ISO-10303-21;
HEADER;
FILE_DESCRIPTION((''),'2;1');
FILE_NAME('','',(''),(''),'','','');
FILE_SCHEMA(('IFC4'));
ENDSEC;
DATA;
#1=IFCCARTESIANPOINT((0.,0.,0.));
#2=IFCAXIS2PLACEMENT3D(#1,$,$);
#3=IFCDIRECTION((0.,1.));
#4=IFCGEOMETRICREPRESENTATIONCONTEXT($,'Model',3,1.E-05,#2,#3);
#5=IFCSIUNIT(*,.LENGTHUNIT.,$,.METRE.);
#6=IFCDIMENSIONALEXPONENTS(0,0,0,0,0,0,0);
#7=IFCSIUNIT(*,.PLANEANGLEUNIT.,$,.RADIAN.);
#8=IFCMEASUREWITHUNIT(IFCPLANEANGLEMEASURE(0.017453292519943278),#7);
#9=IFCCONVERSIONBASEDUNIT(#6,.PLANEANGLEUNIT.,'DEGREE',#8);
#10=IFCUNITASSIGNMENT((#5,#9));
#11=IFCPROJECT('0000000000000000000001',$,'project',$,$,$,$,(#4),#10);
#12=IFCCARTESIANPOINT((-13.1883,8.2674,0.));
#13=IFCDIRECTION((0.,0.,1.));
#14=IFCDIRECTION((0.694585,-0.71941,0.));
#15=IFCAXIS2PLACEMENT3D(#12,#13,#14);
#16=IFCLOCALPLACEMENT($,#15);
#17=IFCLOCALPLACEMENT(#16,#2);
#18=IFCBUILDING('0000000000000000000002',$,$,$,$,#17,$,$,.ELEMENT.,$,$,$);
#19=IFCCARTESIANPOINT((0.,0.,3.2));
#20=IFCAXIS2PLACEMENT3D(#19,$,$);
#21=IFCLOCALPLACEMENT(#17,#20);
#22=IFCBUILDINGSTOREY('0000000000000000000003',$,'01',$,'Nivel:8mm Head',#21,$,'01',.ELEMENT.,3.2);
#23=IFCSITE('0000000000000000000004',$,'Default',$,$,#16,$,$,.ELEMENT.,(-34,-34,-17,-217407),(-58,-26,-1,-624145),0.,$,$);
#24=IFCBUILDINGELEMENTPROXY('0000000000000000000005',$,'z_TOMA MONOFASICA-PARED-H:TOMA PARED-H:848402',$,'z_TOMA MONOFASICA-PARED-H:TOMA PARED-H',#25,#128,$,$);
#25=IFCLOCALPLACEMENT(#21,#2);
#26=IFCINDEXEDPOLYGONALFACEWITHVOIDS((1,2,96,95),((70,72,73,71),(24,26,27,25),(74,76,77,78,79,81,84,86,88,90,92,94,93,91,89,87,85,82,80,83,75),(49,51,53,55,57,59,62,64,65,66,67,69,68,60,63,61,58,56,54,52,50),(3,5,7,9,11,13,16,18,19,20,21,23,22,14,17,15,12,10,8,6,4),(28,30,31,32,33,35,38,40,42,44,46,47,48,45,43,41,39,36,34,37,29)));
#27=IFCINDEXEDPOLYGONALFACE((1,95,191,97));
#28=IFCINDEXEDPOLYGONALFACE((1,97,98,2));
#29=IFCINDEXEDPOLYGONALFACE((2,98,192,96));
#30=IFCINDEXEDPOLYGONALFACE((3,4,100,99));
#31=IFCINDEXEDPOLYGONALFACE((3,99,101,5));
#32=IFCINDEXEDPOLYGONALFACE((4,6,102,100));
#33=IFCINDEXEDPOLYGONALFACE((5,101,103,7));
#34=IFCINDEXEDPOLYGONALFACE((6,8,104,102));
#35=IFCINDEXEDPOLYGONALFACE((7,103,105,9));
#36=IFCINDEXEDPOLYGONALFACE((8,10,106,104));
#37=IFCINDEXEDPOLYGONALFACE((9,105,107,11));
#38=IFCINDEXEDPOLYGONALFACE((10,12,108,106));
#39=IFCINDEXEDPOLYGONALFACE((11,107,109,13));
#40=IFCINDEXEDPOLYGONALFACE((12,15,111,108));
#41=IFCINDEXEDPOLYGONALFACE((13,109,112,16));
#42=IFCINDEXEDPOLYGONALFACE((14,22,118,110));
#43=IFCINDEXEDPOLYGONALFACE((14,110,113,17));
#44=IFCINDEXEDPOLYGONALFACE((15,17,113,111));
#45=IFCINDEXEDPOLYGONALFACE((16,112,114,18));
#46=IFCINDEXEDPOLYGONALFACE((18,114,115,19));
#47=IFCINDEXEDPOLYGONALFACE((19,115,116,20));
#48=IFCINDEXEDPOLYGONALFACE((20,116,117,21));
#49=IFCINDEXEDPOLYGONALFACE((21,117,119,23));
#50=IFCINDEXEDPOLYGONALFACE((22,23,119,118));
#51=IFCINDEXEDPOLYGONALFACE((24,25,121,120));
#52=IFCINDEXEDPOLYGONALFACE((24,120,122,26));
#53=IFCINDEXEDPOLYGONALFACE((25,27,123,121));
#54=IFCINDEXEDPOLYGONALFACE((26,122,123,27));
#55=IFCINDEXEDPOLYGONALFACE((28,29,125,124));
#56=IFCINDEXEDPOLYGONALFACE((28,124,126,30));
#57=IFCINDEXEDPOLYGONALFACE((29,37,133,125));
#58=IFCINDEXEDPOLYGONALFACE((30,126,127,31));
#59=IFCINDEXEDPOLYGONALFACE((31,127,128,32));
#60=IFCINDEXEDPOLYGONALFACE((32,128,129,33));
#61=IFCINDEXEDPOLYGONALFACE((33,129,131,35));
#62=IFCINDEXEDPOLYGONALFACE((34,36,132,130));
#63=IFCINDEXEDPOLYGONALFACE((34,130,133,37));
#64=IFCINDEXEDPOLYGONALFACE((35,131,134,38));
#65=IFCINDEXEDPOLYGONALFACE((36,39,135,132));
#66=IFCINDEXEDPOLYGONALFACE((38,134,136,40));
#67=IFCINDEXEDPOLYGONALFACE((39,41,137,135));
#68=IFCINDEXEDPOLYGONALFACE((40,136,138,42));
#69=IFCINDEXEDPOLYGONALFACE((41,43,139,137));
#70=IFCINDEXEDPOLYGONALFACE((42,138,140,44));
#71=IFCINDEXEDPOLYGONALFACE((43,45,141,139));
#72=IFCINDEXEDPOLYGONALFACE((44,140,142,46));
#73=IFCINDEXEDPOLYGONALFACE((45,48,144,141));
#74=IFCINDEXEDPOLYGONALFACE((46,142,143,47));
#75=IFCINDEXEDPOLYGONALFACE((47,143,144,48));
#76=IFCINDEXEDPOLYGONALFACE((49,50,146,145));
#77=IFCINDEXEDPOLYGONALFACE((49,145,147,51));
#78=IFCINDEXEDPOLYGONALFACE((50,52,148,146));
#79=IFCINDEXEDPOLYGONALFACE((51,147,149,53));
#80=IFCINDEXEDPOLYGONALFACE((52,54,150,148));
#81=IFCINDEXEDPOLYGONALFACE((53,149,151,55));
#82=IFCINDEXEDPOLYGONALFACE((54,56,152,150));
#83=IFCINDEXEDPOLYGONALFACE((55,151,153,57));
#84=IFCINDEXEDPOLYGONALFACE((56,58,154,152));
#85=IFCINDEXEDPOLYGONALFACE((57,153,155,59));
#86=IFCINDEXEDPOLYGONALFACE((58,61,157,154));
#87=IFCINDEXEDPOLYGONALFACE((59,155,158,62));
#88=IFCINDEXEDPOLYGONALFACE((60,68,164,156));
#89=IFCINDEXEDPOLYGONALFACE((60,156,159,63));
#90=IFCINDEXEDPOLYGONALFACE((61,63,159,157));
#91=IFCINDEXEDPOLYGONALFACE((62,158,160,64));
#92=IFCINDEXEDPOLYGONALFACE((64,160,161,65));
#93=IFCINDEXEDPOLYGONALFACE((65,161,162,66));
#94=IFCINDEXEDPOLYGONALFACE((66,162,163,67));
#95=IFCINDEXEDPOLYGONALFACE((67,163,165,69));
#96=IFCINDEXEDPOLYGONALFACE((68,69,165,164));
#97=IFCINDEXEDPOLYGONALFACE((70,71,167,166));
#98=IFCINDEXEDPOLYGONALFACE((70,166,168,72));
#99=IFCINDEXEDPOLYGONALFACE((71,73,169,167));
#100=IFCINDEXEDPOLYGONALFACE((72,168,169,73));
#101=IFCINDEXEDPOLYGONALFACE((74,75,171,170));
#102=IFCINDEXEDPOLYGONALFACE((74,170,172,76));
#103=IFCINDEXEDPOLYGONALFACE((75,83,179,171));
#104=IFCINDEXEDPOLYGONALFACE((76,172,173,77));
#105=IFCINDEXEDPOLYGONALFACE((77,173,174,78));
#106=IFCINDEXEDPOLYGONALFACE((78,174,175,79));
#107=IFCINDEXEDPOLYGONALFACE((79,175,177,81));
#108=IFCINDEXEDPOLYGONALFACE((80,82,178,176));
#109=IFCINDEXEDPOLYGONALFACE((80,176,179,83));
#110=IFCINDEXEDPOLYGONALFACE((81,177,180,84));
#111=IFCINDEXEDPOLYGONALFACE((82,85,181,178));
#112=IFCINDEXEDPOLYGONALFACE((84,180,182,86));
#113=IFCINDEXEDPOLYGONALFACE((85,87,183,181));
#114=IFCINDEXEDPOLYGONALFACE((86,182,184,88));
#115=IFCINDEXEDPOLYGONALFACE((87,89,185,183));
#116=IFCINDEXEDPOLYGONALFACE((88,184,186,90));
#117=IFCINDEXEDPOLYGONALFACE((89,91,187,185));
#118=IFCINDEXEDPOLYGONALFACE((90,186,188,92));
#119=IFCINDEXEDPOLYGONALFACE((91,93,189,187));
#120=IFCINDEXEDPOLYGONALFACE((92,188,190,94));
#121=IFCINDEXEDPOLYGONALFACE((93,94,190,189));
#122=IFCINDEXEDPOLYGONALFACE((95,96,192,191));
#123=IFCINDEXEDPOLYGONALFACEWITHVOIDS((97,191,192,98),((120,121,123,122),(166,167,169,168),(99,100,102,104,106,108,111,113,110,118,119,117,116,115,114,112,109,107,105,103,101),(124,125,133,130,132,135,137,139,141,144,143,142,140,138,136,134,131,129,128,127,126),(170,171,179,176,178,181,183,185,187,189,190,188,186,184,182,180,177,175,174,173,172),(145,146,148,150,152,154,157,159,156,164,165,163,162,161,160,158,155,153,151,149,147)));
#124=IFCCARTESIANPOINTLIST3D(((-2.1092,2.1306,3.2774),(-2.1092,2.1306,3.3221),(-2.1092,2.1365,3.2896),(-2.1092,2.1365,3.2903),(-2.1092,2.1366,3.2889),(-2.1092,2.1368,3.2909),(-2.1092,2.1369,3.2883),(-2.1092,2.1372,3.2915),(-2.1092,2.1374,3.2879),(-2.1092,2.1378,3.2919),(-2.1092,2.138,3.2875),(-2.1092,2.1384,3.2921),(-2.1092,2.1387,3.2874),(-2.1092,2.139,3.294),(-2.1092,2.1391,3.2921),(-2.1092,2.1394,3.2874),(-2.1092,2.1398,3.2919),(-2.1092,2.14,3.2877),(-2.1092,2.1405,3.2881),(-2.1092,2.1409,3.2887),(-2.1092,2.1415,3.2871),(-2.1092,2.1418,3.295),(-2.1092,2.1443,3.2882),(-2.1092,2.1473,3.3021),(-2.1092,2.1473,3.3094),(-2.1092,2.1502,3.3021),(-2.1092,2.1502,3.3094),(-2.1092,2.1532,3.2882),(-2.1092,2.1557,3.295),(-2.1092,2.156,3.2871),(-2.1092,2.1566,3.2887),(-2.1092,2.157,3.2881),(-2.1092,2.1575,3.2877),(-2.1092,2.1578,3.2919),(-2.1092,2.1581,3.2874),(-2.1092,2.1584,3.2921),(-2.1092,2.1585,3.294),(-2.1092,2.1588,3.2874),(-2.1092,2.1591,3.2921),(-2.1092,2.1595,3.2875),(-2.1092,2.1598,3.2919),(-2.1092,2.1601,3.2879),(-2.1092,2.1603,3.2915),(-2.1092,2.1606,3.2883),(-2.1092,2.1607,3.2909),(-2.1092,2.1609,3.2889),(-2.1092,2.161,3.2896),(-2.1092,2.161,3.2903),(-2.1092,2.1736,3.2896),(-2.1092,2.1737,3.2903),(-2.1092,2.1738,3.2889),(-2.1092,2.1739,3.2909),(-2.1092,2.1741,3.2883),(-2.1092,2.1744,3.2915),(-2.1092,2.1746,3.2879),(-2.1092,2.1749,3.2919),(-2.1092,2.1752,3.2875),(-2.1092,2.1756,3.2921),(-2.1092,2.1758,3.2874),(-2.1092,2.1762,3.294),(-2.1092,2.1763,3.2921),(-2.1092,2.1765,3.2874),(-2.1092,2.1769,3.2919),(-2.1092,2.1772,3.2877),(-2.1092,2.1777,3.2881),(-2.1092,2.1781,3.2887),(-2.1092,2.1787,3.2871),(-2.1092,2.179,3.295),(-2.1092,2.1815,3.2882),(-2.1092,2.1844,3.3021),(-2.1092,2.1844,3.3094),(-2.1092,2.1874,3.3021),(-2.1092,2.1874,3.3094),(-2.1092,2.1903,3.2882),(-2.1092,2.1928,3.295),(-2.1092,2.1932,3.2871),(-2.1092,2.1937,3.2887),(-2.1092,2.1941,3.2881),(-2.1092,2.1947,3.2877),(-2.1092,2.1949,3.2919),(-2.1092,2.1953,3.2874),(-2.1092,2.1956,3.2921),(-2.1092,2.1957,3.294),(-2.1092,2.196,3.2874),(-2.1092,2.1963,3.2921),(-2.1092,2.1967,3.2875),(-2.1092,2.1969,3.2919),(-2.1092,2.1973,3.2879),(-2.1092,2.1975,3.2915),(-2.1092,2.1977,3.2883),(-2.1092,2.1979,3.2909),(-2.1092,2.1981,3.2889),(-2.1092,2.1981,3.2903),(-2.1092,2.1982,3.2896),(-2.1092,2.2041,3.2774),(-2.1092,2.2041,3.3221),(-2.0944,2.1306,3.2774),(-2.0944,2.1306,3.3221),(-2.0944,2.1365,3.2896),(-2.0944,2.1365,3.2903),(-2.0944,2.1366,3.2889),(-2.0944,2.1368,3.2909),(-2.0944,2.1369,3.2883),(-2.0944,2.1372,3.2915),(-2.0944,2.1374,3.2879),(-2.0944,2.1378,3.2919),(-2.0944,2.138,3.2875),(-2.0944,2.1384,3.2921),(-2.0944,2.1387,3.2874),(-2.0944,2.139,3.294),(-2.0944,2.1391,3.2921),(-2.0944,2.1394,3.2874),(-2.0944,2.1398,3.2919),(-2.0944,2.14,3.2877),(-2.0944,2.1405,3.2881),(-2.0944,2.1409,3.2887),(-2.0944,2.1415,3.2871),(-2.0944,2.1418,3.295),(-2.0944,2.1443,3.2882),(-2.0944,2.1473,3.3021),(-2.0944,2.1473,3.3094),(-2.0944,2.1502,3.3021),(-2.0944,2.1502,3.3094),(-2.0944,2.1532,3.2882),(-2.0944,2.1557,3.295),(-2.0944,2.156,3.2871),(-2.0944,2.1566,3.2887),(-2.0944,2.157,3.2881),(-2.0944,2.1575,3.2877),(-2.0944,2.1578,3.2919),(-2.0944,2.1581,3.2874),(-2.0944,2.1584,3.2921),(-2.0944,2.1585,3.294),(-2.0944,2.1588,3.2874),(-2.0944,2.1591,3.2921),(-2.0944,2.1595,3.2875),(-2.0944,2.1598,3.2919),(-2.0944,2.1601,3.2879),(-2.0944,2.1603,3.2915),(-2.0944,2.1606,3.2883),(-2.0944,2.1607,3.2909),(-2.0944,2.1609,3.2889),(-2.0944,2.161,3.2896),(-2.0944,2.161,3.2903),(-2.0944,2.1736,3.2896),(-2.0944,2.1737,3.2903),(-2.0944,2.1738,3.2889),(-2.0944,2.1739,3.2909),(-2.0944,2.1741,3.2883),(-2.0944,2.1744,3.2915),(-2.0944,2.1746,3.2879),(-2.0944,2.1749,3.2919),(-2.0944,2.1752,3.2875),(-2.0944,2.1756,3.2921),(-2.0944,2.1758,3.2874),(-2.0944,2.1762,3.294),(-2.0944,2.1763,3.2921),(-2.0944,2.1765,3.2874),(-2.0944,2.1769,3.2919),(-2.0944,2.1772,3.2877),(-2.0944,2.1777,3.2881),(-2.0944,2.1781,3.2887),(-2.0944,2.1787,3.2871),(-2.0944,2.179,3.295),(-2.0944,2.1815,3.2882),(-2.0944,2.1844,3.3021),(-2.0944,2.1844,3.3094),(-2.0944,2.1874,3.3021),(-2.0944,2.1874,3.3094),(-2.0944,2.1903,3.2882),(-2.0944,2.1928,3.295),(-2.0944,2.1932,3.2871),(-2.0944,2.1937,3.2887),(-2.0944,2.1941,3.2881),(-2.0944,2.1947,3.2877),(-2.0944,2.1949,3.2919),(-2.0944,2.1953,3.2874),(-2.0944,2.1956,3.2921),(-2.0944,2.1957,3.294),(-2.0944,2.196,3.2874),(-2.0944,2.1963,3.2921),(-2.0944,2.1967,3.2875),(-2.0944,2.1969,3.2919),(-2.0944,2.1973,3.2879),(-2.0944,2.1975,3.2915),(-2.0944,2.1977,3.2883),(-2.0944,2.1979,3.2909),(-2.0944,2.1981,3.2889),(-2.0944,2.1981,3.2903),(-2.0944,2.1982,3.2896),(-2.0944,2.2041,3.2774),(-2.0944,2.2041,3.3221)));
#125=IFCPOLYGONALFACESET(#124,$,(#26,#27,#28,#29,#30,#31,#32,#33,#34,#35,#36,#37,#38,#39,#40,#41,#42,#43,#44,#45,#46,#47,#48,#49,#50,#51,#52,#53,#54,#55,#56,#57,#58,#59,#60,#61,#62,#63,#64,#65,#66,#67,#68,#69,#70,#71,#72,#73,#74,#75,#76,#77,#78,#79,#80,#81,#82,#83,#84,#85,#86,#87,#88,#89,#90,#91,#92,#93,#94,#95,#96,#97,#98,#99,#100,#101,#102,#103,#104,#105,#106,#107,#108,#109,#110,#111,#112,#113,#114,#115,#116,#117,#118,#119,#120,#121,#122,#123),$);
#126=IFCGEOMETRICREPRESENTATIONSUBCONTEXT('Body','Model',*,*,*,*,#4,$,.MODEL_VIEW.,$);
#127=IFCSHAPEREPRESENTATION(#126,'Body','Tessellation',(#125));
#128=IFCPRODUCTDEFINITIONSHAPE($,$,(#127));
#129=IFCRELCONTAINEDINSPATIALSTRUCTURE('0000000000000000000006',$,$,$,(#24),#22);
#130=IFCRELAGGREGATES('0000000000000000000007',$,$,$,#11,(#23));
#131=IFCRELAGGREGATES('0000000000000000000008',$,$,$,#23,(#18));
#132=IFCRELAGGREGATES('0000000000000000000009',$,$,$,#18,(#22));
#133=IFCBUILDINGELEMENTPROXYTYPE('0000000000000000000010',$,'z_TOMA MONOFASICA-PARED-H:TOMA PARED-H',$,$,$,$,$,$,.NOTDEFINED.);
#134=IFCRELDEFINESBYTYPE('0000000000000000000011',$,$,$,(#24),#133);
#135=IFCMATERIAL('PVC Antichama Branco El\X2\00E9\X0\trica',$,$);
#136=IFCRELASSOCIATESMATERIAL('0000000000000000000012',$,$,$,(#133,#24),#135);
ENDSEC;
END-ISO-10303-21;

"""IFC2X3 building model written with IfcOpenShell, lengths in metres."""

from ifc_helpers import new_model, entity, si_unit, converted_unit, direction, frame, frame_2d, origin, place, context, subcontext, project, spatial, polyline, circle_curve, parameter, trimmed, segment, composite_curve, outline, extrude, source, transform, mapped, material, type_object, type_shapes, element, save


model = new_model("IFC2X3")

# Units and contexts
model_context = context("Model", 3, precision=1e-05, world=origin(), true_north=direction((0.0, 1.0)))
body_context = subcontext(model_context, "Body", "Model", "MODEL_VIEW")
ifc_project = project(units=[si_unit("LENGTHUNIT", "METRE"), converted_unit("PLANEANGLEUNIT", "DEGREE", entity("IfcPlaneAngleMeasure", 0.017453292519943278), si_unit("PLANEANGLEUNIT", "RADIAN"), dimensions=[0, 0, 0, 0, 0, 0, 0])], contexts=[model_context])

# Site, building, storey
site_placement = place(None, frame((-13.1883, 8.2674, 0.0), z_axis=(0.0, 0.0, 1.0), x_axis=(0.694585, -0.71941, 0.0)))
site = spatial("IfcSite", under=ifc_project, at=site_placement, Name="Default", CompositionType="ELEMENT", RefLatitude=(-34, -34, -17, -217407), RefLongitude=(-58, -26, -1, -624145), RefElevation=0.0)
building_placement = place(site_placement, origin())
building = spatial("IfcBuilding", under=site, at=building_placement, CompositionType="ELEMENT")
storey_placement = place(building_placement, frame((0.0, 0.0, 3.2)))
storey = spatial("IfcBuildingStorey", under=building, at=storey_placement, Name="01", ObjectType="Nivel:8mm Head", LongName="01", CompositionType="ELEMENT", Elevation=3.2)

# Building element proxy
ifc_material_1 = material(Name="PVC Antichama Branco Elétrica")
building_element_proxy_type_1 = type_object("IfcBuildingElementProxyType", Name="z_TOMA MONOFASICA-PARED-H:TOMA PARED-H", PredefinedType="NOTDEFINED", material=ifc_material_1)
shared_shape_1 = source(origin(), body_context, "Body", "SweptSolid", [
    extrude(outline(polyline([(-0.0368, -0.0223), (0.0368, -0.0223), (0.0368, 0.0223), (-0.0368, 0.0223), (-0.0368, -0.0223)]), holes=[composite_curve([segment(polyline([(0.0141, 0.0115), (0.0116, 0.0047)]), True, "CONTINUOUS"), segment(polyline([(0.0116, 0.0047), (0.0088, 0.0057)]), True, "CONTINUOUS"), segment(polyline([(0.0088, 0.0057), (0.0096, 0.0078)]), True, "CONTINUOUS"), segment(trimmed(circle_curve(frame_2d((0.0087, 0.0099), x_axis=(1.0, 0.0)), 0.0024), [parameter(27.118901)], [parameter(292.881099)], True, "PARAMETER"), False, "CONTINUOUS"), segment(polyline([(0.0108, 0.011), (0.0113, 0.0126)]), True, "CONTINUOUS"), segment(polyline([(0.0113, 0.0126), (0.0141, 0.0115)]), True, "CONTINUOUS")], self_intersect=False), composite_curve([segment(polyline([(0.0255, 0.0047), (0.023, 0.0115)]), True, "CONTINUOUS"), segment(polyline([(0.023, 0.0115), (0.0258, 0.0126)]), True, "CONTINUOUS"), segment(polyline([(0.0258, 0.0126), (0.0264, 0.011)]), True, "CONTINUOUS"), segment(trimmed(circle_curve(frame_2d((0.0285, 0.0099), x_axis=(1.0, 0.0)), 0.0024), [parameter(247.118901)], [parameter(152.881099)], True, "PARAMETER"), False, "CONTINUOUS"), segment(polyline([(0.0276, 0.0078), (0.0283, 0.0057)]), True, "CONTINUOUS"), segment(polyline([(0.0283, 0.0057), (0.0255, 0.0047)]), True, "CONTINUOUS")], self_intersect=False), polyline([(0.0201, -0.0024), (0.0201, -0.0097), (0.0171, -0.0097), (0.0171, -0.0024), (0.0201, -0.0024)]), composite_curve([segment(polyline([(-0.0141, 0.0115), (-0.0113, 0.0126)]), True, "CONTINUOUS"), segment(polyline([(-0.0113, 0.0126), (-0.0108, 0.011)]), True, "CONTINUOUS"), segment(trimmed(circle_curve(frame_2d((-0.0087, 0.0099), x_axis=(1.0, 0.0)), 0.0024), [parameter(247.118901)], [parameter(152.881099)], True, "PARAMETER"), False, "CONTINUOUS"), segment(polyline([(-0.0096, 0.0078), (-0.0088, 0.0057)]), True, "CONTINUOUS"), segment(polyline([(-0.0088, 0.0057), (-0.0116, 0.0047)]), True, "CONTINUOUS"), segment(polyline([(-0.0116, 0.0047), (-0.0141, 0.0115)]), True, "CONTINUOUS")], self_intersect=False), composite_curve([segment(polyline([(-0.0255, 0.0047), (-0.0283, 0.0057)]), True, "CONTINUOUS"), segment(polyline([(-0.0283, 0.0057), (-0.0276, 0.0078)]), True, "CONTINUOUS"), segment(trimmed(circle_curve(frame_2d((-0.0285, 0.0099), x_axis=(1.0, 0.0)), 0.0024), [parameter(27.118901)], [parameter(292.881099)], True, "PARAMETER"), False, "CONTINUOUS"), segment(polyline([(-0.0264, 0.011), (-0.0258, 0.0126)]), True, "CONTINUOUS"), segment(polyline([(-0.0258, 0.0126), (-0.023, 0.0115)]), True, "CONTINUOUS"), segment(polyline([(-0.023, 0.0115), (-0.0255, 0.0047)]), True, "CONTINUOUS")], self_intersect=False), polyline([(-0.0201, -0.0024), (-0.0171, -0.0024), (-0.0171, -0.0097), (-0.0201, -0.0097), (-0.0201, -0.0024)])]), frame((0.0, -0.005, 0.0223), z_axis=(0.0, 1.0, 0.0), x_axis=(1.0, 0.0, 0.0)), (0.0, 0.0, 1.0), 0.0148),
])
type_shapes(building_element_proxy_type_1, [shared_shape_1])
for number, where, z_axis, x_axis, name in (
    (1, (-2.0994, 2.1673, 3.2774), (0.0, 0.0, 1.0), (0.0, 1.0, 0.0), "z_TOMA MONOFASICA-PARED-H:TOMA PARED-H:848402"),
):
    element("IfcBuildingElementProxy", number, at=place(storey_placement, frame(where, z_axis=z_axis, x_axis=x_axis)), inside=storey, type_object=building_element_proxy_type_1, material=ifc_material_1, Name=name, ObjectType="z_TOMA MONOFASICA-PARED-H:TOMA PARED-H", context=body_context, shape_type="MappedRepresentation", body=[
        mapped(shared_shape_1, transform((0.0, 0.0, 0.0), scale=1.0)),
    ])

save(model, "model.ifc")
